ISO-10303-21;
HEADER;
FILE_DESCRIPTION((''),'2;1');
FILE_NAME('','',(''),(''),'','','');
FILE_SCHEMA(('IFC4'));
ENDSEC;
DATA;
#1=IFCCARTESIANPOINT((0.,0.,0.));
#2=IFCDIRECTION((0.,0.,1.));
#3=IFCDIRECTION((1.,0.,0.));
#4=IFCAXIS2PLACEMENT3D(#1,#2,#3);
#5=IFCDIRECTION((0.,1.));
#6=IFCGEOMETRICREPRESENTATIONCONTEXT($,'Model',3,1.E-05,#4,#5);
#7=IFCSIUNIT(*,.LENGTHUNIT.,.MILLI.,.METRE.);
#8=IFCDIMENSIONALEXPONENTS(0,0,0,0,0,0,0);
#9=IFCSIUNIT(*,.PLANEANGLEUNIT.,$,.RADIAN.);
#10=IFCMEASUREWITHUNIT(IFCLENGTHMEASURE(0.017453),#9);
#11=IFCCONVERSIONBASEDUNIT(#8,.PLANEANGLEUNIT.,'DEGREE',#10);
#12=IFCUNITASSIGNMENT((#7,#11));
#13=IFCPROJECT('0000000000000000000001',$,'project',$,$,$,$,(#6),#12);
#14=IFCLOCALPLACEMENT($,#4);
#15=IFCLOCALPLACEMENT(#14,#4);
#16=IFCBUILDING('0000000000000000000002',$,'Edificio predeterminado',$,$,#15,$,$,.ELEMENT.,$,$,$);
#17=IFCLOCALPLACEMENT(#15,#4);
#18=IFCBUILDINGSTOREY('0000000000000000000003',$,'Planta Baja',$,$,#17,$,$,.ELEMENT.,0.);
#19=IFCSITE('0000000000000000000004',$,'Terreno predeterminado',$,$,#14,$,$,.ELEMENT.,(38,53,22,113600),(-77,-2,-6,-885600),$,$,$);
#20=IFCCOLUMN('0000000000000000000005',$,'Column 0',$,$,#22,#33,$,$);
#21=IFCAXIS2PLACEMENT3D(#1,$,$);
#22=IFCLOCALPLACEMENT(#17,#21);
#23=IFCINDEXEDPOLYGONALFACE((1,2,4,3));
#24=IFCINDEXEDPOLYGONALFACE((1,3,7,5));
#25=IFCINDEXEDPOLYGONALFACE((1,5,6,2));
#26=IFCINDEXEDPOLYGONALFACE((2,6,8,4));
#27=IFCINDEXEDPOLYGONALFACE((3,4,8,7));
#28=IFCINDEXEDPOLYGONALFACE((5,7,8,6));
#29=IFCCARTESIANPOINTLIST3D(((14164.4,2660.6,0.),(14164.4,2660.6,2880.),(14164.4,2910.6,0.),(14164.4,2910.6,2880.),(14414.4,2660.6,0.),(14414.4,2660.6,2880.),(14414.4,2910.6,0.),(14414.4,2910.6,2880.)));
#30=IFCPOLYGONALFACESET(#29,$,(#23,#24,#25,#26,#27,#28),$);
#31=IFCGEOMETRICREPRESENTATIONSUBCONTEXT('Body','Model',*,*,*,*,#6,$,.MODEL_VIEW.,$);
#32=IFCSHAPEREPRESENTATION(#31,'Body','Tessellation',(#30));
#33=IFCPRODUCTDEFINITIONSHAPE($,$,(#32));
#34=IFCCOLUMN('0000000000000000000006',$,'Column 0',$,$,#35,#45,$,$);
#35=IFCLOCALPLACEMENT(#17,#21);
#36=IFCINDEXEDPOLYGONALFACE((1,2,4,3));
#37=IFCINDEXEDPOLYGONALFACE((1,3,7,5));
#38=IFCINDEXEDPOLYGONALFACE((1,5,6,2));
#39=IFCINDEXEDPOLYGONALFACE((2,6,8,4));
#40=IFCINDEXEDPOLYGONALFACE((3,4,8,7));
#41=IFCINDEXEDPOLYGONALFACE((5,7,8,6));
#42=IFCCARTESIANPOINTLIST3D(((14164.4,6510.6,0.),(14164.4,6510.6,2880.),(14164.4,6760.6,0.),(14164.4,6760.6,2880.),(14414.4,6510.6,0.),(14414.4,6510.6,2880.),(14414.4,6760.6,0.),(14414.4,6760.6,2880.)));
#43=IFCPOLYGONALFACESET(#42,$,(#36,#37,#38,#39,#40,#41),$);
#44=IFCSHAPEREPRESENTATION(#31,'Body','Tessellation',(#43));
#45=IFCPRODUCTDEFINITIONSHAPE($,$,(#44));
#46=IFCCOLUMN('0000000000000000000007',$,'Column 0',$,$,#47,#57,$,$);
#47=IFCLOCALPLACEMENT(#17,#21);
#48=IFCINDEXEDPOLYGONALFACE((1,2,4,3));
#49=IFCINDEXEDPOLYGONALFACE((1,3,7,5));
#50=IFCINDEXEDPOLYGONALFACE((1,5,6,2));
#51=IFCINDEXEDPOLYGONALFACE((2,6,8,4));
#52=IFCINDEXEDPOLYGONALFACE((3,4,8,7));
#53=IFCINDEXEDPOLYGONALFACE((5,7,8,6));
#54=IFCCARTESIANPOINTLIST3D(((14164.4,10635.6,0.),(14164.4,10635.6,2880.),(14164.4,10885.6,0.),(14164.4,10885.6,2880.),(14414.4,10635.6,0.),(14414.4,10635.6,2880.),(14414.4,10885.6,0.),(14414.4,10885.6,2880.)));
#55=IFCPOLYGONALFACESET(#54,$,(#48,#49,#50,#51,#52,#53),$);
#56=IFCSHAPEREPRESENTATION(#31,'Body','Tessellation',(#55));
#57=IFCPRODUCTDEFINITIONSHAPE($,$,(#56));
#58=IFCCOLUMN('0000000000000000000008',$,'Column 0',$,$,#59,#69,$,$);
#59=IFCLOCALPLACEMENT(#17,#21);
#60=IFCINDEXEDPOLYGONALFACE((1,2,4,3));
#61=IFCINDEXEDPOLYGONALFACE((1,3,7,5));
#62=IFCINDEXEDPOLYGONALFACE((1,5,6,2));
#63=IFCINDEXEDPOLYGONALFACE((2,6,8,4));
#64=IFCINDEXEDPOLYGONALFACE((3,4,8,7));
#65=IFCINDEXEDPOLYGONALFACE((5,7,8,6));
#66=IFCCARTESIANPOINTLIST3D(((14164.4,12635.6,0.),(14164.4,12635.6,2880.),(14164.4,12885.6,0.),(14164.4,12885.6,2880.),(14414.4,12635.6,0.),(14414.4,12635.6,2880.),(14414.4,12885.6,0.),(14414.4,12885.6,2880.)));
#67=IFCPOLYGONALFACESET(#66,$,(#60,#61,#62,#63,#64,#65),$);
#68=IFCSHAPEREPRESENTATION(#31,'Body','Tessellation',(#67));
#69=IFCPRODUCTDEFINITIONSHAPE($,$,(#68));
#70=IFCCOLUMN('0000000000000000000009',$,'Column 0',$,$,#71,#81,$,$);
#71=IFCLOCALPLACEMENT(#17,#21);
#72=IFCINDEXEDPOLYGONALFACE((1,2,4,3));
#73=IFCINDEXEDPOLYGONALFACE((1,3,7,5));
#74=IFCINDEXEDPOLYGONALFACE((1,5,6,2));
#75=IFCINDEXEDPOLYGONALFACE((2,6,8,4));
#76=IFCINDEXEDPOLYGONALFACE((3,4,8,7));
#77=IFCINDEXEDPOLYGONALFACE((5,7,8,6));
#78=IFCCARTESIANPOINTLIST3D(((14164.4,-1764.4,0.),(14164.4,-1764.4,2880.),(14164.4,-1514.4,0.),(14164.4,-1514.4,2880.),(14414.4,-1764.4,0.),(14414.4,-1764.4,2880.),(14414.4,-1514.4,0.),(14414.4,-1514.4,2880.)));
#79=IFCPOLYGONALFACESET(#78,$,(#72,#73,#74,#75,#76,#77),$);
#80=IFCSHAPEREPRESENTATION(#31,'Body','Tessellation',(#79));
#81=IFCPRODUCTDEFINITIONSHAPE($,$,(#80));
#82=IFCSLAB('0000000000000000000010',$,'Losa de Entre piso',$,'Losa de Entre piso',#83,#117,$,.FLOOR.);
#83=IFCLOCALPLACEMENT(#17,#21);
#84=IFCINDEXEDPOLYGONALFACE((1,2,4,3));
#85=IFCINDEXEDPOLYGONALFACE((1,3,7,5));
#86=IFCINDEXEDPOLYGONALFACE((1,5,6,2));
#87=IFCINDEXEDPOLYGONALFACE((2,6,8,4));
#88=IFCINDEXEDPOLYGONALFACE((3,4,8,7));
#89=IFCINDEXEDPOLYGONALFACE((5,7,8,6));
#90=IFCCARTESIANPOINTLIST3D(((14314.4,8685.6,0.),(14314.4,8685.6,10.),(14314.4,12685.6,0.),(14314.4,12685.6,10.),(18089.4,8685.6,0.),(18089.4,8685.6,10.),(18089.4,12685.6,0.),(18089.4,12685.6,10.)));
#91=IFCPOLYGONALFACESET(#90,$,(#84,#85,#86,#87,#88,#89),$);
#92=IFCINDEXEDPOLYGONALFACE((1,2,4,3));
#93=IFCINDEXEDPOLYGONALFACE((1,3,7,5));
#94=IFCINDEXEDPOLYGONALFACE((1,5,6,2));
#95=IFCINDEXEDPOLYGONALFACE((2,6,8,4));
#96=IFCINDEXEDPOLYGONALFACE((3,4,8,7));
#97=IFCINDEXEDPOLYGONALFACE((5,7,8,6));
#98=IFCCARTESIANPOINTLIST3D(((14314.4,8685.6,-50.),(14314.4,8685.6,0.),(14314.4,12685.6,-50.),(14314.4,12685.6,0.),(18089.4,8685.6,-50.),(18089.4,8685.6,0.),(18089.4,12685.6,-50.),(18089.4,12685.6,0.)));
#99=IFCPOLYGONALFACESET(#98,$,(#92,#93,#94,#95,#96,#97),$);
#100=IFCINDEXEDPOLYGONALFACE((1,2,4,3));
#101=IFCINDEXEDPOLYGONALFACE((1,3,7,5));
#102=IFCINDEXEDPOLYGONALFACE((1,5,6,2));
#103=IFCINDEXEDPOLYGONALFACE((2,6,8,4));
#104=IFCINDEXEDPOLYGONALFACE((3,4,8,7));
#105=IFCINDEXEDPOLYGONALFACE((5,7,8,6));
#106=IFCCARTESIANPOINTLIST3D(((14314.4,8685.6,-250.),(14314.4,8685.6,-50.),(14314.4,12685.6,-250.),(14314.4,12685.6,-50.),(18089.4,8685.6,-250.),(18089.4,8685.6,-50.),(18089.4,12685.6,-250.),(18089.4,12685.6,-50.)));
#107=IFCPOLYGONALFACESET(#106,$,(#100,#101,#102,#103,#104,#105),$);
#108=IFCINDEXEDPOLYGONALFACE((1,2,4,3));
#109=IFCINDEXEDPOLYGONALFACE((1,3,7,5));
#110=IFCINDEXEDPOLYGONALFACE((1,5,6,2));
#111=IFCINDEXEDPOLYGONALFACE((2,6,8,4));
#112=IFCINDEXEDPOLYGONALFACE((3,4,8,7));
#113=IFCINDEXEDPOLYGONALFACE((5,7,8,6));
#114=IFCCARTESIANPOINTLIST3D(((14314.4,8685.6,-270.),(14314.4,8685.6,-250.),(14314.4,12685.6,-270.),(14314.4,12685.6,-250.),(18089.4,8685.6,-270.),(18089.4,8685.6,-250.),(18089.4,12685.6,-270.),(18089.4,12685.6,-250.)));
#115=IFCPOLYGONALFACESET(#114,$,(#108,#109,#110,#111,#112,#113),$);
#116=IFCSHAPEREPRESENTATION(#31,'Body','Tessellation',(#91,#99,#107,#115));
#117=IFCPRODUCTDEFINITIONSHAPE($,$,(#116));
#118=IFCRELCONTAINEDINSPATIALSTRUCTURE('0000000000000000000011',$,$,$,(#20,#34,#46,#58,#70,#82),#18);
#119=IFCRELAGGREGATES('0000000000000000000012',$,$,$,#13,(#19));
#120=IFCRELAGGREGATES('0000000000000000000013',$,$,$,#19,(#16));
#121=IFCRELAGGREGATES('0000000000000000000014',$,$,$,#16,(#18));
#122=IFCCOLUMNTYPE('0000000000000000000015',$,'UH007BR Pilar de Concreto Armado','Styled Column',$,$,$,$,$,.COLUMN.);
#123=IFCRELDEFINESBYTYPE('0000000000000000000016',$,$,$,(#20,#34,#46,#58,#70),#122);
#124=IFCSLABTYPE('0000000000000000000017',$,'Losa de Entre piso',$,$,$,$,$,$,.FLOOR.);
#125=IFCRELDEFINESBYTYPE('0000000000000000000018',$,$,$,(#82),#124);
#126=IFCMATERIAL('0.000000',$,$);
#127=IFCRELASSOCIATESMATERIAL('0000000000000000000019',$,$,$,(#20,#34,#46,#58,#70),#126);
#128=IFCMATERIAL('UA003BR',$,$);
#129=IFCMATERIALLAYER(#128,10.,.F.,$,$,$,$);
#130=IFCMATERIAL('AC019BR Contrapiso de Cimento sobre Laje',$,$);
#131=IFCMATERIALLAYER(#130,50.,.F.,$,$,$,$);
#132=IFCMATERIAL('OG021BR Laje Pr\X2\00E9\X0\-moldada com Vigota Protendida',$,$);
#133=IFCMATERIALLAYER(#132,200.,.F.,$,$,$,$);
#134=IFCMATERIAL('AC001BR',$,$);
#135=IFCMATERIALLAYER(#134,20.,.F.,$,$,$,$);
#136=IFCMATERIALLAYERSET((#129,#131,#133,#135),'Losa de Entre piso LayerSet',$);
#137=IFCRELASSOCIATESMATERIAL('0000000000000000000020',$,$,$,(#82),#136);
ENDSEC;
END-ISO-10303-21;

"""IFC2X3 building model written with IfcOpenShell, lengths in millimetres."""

from ifc_helpers import new_model, entity, si_unit, converted_unit, direction, frame, origin_with_axes, place, context, subcontext, project, spatial, polyline, outline, extrude, material, layer, layer_set, layer_usage, type_object, element, save


model = new_model("IFC2X3")

# Units and contexts
model_context = context("Model", 3, precision=1e-05, world=origin_with_axes(), true_north=direction((0.0, 1.0)))
body_context = subcontext(model_context, "Body", "Model", "MODEL_VIEW")
ifc_project = project(units=[si_unit("LENGTHUNIT", "METRE", prefix="MILLI"), converted_unit("PLANEANGLEUNIT", "DEGREE", entity("IfcLengthMeasure", 0.017453), si_unit("PLANEANGLEUNIT", "RADIAN"), dimensions=[0, 0, 0, 0, 0, 0, 0])], contexts=[model_context])

# Site, building, storey
site_placement = place(None, origin_with_axes())
site = spatial("IfcSite", under=ifc_project, at=site_placement, Name="Terreno predeterminado", CompositionType="ELEMENT", RefLatitude=(38, 53, 22, 113600), RefLongitude=(-77, -2, -6, -885600))
building_placement = place(site_placement, origin_with_axes())
building = spatial("IfcBuilding", under=site, at=building_placement, Name="Edificio predeterminado", CompositionType="ELEMENT")
storey_placement = place(building_placement, origin_with_axes())
storey = spatial("IfcBuildingStorey", under=building, at=storey_placement, Name="Planta Baja", CompositionType="ELEMENT", Elevation=0.0)

# Columns
ifc_material_1 = material(Name="0.000000")
column_type = type_object("IfcColumnType", Name="UH007BR Pilar de Concreto Armado", Description="Styled Column", PredefinedType="COLUMN")
for number, where, z_axis, x_axis, name in (
    (1, (14289.4, 2785.6, 0.0), (0.0, 0.0, 1.0), (1.0, 0.0, 0.0), "Column 0"),
    (2, (14289.4, 6635.6, 0.0), (0.0, 0.0, 1.0), (1.0, 0.0, 0.0), "Column 0"),
    (3, (14289.4, 10760.6, 0.0), (0.0, 0.0, 1.0), (1.0, 0.0, 0.0), "Column 0"),
    (4, (14289.4, 12760.6, 0.0), (0.0, 0.0, 1.0), (1.0, 0.0, 0.0), "Column 0"),
    (5, (14289.4, -1639.4, 0.0), (0.0, 0.0, 1.0), (1.0, 0.0, 0.0), "Column 0"),
):
    element("IfcColumn", number, at=place(storey_placement, frame(where, z_axis=z_axis, x_axis=x_axis)), inside=storey, type_object=column_type, material=ifc_material_1, Name=name, context=body_context, shape_type="SweptSolid", body=[
        extrude(outline(polyline([(-125.0, -125.0), (125.0, -125.0), (125.0, 125.0), (-125.0, 125.0), (-125.0, -125.0)])), origin_with_axes(), (0.0, 0.0, 1.0), 2880.0),
    ])

# Slab
ifc_material_2 = material(Name="UA003BR")
ifc_layer_1 = layer(ifc_material_2, 10.0, ventilated=False)
ifc_material_3 = material(Name="AC019BR Contrapiso de Cimento sobre Laje")
ifc_layer_2 = layer(ifc_material_3, 50.0, ventilated=False)
ifc_material_4 = material(Name="OG021BR Laje Pré-moldada com Vigota Protendida")
ifc_layer_3 = layer(ifc_material_4, 200.0, ventilated=False)
ifc_material_5 = material(Name="AC001BR")
ifc_layer_4 = layer(ifc_material_5, 20.0, ventilated=False)
ifc_layer_set_1 = layer_set([ifc_layer_1, ifc_layer_2, ifc_layer_3, ifc_layer_4], Name="Losa de Entre piso LayerSet")
ifc_layer_usage_1 = layer_usage(ifc_layer_set_1, "AXIS3", "NEGATIVE", 0.0)
slab_type = type_object("IfcSlabType", Name="Losa de Entre piso", PredefinedType="FLOOR")
slab_1_placement = place(storey_placement, origin_with_axes())
element("IfcSlab", 6, at=slab_1_placement, inside=storey, type_object=slab_type, material=ifc_layer_usage_1, Name="Losa de Entre piso", ObjectType="Losa de Entre piso", PredefinedType="FLOOR", context=body_context, shape_type="SweptSolid", body=[
    extrude(outline(polyline([(0.0, 4000.0), (3775.0, 4000.0), (3775.0, 0.0), (0.0, 0.0), (0.0, 4000.0)])), frame((14314.4, 12685.6, 0.0), z_axis=(0.0, 0.0, -1.0), x_axis=(1.0, 0.0, 0.0)), (0.0, 0.0, -1.0), 10.0),
    extrude(outline(polyline([(0.0, 4000.0), (3775.0, 4000.0), (3775.0, 0.0), (0.0, 0.0), (0.0, 4000.0)])), frame((14314.4, 12685.6, -50.0), z_axis=(0.0, 0.0, -1.0), x_axis=(1.0, 0.0, 0.0)), (0.0, 0.0, -1.0), 50.0),
    extrude(outline(polyline([(0.0, 4000.0), (3775.0, 4000.0), (3775.0, 0.0), (0.0, 0.0), (0.0, 4000.0)])), frame((14314.4, 12685.6, -250.0), z_axis=(0.0, 0.0, -1.0), x_axis=(1.0, 0.0, 0.0)), (0.0, 0.0, -1.0), 200.0),
    extrude(outline(polyline([(0.0, 4000.0), (3775.0, 4000.0), (3775.0, 0.0), (0.0, 0.0), (0.0, 4000.0)])), frame((14314.4, 12685.6, -270.0), z_axis=(0.0, 0.0, -1.0), x_axis=(1.0, 0.0, 0.0)), (0.0, 0.0, -1.0), 20.0),
])

save(model, "model.ifc")
